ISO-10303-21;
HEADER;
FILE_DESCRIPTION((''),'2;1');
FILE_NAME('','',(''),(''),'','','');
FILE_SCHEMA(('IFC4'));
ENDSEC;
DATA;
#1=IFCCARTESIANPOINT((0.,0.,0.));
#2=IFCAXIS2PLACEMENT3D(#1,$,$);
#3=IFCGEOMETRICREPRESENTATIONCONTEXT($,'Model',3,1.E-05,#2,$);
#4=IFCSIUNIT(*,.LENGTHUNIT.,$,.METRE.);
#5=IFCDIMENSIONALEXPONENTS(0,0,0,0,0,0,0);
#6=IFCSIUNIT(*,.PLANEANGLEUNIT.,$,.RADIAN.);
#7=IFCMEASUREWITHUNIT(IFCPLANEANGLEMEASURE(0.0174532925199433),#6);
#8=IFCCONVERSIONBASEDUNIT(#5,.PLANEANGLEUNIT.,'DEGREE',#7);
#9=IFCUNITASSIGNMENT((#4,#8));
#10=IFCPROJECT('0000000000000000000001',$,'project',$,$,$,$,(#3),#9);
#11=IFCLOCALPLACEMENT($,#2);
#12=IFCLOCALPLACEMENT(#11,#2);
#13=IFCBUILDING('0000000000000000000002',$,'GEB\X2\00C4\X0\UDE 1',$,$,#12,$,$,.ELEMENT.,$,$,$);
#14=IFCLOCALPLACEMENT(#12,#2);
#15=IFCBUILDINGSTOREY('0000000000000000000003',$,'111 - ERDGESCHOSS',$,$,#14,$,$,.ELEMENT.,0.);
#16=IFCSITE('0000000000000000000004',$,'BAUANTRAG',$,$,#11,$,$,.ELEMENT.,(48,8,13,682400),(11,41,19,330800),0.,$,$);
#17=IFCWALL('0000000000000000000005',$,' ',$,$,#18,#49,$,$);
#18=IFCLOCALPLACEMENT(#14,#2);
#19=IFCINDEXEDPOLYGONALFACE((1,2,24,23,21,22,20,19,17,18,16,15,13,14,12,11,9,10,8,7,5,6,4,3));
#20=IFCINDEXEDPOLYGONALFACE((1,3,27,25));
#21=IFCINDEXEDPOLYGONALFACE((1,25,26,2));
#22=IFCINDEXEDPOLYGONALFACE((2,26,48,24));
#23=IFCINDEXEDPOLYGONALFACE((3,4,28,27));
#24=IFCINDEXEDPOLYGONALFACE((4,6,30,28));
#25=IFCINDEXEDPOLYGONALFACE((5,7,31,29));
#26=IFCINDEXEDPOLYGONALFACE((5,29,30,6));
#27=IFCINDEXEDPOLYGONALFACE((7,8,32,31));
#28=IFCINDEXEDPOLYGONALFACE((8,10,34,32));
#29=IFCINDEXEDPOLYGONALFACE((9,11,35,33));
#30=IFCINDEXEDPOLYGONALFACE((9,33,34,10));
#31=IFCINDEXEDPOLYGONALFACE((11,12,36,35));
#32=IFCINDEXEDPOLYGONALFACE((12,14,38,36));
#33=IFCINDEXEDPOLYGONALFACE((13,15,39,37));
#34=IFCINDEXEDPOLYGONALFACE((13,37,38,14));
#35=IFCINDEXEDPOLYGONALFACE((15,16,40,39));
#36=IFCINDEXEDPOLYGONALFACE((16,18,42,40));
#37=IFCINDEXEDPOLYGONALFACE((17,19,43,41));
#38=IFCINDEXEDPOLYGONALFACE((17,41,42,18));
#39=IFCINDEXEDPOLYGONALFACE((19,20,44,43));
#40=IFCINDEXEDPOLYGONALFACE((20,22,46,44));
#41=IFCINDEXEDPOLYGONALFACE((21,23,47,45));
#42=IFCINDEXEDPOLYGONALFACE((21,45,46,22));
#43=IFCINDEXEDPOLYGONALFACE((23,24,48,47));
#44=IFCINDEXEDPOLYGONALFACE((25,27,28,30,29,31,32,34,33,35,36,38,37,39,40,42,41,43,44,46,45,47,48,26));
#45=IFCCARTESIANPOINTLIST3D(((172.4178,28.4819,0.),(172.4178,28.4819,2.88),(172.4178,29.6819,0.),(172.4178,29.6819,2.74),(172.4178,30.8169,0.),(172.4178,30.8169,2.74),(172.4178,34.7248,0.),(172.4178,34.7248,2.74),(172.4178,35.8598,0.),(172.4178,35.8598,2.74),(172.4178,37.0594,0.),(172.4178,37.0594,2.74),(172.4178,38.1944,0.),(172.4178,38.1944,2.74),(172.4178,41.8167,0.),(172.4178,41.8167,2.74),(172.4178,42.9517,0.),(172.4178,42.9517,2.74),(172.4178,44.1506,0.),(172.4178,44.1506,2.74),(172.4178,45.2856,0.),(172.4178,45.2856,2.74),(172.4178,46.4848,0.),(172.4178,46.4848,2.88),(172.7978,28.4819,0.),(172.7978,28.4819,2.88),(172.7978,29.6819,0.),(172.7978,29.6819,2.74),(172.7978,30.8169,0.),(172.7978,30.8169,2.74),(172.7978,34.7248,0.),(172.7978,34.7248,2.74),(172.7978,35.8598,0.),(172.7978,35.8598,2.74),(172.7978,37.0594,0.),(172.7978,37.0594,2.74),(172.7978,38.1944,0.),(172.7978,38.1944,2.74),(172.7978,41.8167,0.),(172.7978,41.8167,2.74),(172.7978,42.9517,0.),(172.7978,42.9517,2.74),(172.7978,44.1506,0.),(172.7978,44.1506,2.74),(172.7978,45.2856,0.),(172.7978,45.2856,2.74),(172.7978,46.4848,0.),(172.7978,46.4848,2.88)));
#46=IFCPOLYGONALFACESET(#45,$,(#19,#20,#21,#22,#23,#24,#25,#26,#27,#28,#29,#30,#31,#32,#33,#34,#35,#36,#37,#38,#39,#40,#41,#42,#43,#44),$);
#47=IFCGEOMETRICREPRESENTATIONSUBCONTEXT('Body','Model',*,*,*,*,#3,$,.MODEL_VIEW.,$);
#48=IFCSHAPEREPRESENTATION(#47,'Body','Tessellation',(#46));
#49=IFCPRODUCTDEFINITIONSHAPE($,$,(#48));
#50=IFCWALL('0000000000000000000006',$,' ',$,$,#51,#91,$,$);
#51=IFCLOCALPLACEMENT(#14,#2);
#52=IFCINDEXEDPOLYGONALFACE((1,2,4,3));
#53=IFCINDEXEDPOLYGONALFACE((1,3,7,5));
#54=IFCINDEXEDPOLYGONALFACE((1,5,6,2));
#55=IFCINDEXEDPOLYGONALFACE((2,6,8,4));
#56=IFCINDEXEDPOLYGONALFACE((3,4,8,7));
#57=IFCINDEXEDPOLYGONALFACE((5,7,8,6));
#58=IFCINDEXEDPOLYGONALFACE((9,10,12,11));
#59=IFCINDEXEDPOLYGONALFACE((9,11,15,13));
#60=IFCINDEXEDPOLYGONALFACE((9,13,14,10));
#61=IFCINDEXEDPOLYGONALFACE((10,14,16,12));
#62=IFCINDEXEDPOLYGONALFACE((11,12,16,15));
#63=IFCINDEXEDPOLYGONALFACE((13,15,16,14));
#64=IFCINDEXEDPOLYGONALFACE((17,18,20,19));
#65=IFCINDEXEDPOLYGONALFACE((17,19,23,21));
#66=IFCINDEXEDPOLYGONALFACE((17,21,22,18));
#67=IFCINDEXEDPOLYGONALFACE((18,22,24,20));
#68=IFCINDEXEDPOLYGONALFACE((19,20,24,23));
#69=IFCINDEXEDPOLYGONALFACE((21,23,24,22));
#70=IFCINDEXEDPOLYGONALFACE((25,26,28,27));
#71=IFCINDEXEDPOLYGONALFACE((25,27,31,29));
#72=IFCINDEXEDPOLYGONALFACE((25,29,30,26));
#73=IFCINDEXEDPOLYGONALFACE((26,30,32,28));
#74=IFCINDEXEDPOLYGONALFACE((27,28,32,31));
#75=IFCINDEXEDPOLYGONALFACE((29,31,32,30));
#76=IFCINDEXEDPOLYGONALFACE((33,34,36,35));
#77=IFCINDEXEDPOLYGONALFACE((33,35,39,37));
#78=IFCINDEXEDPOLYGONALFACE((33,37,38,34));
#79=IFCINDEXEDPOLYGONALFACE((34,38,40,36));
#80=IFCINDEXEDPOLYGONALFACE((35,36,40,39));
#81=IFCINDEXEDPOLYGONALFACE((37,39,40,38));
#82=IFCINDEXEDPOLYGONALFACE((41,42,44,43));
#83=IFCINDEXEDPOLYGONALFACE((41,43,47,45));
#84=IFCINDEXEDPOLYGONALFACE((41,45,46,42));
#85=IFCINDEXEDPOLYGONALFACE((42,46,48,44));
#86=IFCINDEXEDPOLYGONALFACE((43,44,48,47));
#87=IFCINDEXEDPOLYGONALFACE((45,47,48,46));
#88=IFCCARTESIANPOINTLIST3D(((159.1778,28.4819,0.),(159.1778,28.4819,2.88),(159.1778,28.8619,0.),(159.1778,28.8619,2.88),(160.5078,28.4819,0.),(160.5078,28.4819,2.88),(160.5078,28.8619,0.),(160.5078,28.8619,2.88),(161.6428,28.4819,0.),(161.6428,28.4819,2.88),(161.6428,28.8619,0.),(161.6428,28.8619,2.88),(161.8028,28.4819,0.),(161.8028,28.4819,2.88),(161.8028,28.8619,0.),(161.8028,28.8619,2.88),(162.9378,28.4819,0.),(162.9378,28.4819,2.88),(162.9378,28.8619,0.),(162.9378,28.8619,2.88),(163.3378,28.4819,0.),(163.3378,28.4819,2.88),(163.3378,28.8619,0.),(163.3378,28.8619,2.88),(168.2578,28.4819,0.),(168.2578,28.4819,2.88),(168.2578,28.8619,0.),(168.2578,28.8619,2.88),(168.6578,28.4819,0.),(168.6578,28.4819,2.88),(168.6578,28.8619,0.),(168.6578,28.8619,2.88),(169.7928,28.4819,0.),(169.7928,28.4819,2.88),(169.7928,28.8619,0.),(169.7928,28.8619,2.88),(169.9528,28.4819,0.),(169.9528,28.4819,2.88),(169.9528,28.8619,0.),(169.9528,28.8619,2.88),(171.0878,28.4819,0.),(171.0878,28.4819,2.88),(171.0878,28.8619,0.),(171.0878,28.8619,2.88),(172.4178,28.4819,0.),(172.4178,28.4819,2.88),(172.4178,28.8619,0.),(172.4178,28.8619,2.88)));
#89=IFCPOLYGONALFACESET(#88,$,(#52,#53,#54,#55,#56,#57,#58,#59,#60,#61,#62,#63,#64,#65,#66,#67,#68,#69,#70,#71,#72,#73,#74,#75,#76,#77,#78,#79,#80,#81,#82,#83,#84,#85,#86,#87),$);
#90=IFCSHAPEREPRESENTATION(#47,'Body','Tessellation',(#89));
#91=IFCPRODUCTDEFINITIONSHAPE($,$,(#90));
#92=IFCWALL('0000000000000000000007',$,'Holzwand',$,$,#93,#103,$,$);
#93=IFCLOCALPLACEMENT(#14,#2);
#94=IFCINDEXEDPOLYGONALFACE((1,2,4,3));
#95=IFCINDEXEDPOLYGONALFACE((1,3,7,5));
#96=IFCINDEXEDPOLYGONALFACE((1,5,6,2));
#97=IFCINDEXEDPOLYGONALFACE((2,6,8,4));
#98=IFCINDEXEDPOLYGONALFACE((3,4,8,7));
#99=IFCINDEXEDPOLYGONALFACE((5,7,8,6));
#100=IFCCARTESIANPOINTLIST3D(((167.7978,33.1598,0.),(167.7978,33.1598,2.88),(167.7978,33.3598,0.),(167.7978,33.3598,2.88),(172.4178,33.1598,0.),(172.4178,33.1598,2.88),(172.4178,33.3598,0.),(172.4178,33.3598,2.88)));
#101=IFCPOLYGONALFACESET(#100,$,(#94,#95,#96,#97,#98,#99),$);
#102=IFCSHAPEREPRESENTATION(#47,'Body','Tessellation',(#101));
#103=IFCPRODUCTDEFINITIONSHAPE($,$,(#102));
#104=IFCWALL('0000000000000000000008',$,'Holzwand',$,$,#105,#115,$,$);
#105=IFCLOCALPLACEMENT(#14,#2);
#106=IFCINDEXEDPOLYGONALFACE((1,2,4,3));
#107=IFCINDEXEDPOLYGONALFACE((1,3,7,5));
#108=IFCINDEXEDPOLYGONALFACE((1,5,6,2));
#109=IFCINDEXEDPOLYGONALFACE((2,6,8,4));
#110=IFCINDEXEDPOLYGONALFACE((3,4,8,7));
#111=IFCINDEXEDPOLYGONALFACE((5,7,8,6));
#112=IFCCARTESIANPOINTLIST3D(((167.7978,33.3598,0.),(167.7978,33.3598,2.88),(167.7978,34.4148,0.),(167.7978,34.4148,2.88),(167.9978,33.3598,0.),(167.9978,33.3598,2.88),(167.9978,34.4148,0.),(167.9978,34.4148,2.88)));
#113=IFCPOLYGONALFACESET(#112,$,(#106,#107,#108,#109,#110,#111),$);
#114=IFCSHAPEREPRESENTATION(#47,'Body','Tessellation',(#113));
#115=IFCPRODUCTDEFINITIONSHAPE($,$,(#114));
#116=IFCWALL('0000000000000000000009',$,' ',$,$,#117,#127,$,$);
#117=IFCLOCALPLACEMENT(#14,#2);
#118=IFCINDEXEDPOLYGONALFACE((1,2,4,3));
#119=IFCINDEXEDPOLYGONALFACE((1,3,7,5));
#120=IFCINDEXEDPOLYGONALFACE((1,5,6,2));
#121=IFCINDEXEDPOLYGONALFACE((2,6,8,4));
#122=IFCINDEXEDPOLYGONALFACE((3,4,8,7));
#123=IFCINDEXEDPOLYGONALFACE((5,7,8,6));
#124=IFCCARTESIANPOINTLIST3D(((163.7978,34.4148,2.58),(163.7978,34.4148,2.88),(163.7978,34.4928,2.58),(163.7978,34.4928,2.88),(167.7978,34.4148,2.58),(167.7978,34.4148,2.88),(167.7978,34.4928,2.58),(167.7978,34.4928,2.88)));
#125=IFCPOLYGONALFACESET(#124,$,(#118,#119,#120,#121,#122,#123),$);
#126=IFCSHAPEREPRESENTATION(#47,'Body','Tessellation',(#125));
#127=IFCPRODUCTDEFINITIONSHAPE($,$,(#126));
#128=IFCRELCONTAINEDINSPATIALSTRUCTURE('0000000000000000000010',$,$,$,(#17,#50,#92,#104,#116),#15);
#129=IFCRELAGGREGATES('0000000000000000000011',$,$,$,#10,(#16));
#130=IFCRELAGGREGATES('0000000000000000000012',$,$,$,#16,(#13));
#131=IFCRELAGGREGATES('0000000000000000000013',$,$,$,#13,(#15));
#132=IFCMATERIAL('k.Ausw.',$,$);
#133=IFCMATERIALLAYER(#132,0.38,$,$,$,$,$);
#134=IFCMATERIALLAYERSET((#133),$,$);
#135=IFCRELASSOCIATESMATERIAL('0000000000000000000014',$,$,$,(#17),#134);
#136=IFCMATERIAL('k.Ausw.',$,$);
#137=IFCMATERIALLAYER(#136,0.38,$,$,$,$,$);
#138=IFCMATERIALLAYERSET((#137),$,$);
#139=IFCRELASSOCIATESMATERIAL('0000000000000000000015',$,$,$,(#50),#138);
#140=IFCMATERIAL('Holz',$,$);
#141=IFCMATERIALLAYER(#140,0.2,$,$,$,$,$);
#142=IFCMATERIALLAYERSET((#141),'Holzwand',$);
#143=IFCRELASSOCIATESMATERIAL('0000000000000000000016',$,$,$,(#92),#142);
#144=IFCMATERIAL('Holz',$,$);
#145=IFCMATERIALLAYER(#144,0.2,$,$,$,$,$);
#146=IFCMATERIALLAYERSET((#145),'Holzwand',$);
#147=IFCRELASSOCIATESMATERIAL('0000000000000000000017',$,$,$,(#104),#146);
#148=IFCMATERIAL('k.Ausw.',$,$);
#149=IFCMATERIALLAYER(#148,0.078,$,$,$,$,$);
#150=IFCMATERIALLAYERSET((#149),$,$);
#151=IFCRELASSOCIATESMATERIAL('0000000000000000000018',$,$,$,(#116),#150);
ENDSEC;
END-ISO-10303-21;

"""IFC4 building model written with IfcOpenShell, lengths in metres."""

from ifc_helpers import new_model, entity, si_unit, converted_unit, frame, frame_2d, origin, origin_with_axes, place, context, subcontext, project, spatial, polyline, rectangle, outline, extrude, material, layer, layer_set, layer_usage, element, save


model = new_model("IFC4")

# Units and contexts
model_context = context("Model", 3, precision=1e-05, world=origin())
body_context = subcontext(model_context, "Body", "Model", "MODEL_VIEW")
ifc_project = project(units=[si_unit("LENGTHUNIT", "METRE"), converted_unit("PLANEANGLEUNIT", "DEGREE", entity("IfcPlaneAngleMeasure", 0.0174532925199433), si_unit("PLANEANGLEUNIT", "RADIAN"), dimensions=[0, 0, 0, 0, 0, 0, 0])], contexts=[model_context])

# Site, building, storey
site_placement = place(None, origin())
site = spatial("IfcSite", under=ifc_project, at=site_placement, Name="BAUANTRAG", CompositionType="ELEMENT", RefLatitude=(48, 8, 13, 682400), RefLongitude=(11, 41, 19, 330800), RefElevation=0.0)
building_placement = place(site_placement, origin())
building = spatial("IfcBuilding", under=site, at=building_placement, Name="GEBÄUDE 1", CompositionType="ELEMENT")
storey_placement = place(building_placement, origin())
storey = spatial("IfcBuildingStorey", under=building, at=storey_placement, Name="111 - ERDGESCHOSS", CompositionType="ELEMENT", Elevation=0.0)

# Walls, openings
ifc_material_1 = material(Name="k.Ausw.")
ifc_layer_1 = layer(ifc_material_1, 0.38)
ifc_layer_set_1 = layer_set([ifc_layer_1])
ifc_layer_usage_1 = layer_usage(ifc_layer_set_1, "AXIS2", "POSITIVE", 0.0)
wall_1_placement = place(storey_placement, frame((172.7978, 28.4819, 0.0), z_axis=(0.0, 0.0, 1.0), x_axis=(0.0, 1.0, 0.0)))
wall_1 = element("IfcWall", 1, at=wall_1_placement, inside=storey, material=ifc_layer_usage_1, Name=" ", context=body_context, shape_type="SweptSolid", body=[
    extrude(rectangle(XDim=18.0029, YDim=0.38, at=frame_2d((9.0014, 0.19), x_axis=(1.0, 0.0))), origin_with_axes(), (0.0, 0.0, 1.0), 2.88),
])
opening_1_placement = place(wall_1_placement, frame((8.5775, 0.0, 0.0), z_axis=(0.0, 1.0, 0.0), x_axis=(0.0, 0.0, 1.0)))
element("IfcOpeningElement", 2, at=opening_1_placement, cuts=wall_1, ObjectType="Opening", context=body_context, shape_type="SweptSolid", body=[
    extrude(outline(polyline([(0.0, 1.135), (2.74, 1.135), (2.74, 0.0), (0.0, 0.0), (0.0, 1.135)])), origin_with_axes(), (0.0, 0.0, 1.0), 0.38),
])
opening_2_placement = place(wall_1_placement, frame((15.6687, 0.0, 0.0), z_axis=(0.0, 1.0, 0.0), x_axis=(0.0, 0.0, 1.0)))
element("IfcOpeningElement", 3, at=opening_2_placement, cuts=wall_1, ObjectType="Opening", context=body_context, shape_type="SweptSolid", body=[
    extrude(outline(polyline([(0.0, 1.135), (2.74, 1.135), (2.74, 0.0), (0.0, 0.0), (0.0, 1.135)])), origin_with_axes(), (0.0, 0.0, 1.0), 0.38),
])
opening_3_placement = place(wall_1_placement, frame((1.2, 0.0, 0.0), z_axis=(0.0, 1.0, 0.0), x_axis=(0.0, 0.0, 1.0)))
element("IfcOpeningElement", 4, at=opening_3_placement, cuts=wall_1, ObjectType="Opening", context=body_context, shape_type="SweptSolid", body=[
    extrude(outline(polyline([(0.0, 1.135), (2.74, 1.135), (2.74, 0.0), (0.0, 0.0), (0.0, 1.135)])), origin_with_axes(), (0.0, 0.0, 1.0), 0.38),
])
opening_4_placement = place(wall_1_placement, frame((13.3348, 0.0, 0.0), z_axis=(0.0, 1.0, 0.0), x_axis=(0.0, 0.0, 1.0)))
element("IfcOpeningElement", 5, at=opening_4_placement, cuts=wall_1, ObjectType="Opening", context=body_context, shape_type="SweptSolid", body=[
    extrude(outline(polyline([(0.0, 1.135), (2.74, 1.135), (2.74, 0.0), (0.0, 0.0), (0.0, 1.135)])), origin_with_axes(), (0.0, 0.0, 1.0), 0.38),
])
opening_5_placement = place(wall_1_placement, frame((6.2429, 0.0, 0.0), z_axis=(0.0, 1.0, 0.0), x_axis=(0.0, 0.0, 1.0)))
element("IfcOpeningElement", 6, at=opening_5_placement, cuts=wall_1, ObjectType="Opening", context=body_context, shape_type="SweptSolid", body=[
    extrude(outline(polyline([(0.0, 1.135), (2.74, 1.135), (2.74, 0.0), (0.0, 0.0), (0.0, 1.135)])), origin_with_axes(), (0.0, 0.0, 1.0), 0.38),
])
ifc_material_2 = material(Name="k.Ausw.")
ifc_layer_2 = layer(ifc_material_2, 0.38)
ifc_layer_set_2 = layer_set([ifc_layer_2])
ifc_layer_usage_2 = layer_usage(ifc_layer_set_2, "AXIS2", "POSITIVE", 0.0)
wall_2_placement = place(storey_placement, frame((159.1778, 28.4819, 0.0), z_axis=(0.0, 0.0, 1.0), x_axis=(1.0, 0.0, 0.0)))
wall_2 = element("IfcWall", 7, at=wall_2_placement, inside=storey, material=ifc_layer_usage_2, Name=" ", context=body_context, shape_type="SweptSolid", body=[
    extrude(rectangle(XDim=13.24, YDim=0.38, at=frame_2d((6.62, 0.19), x_axis=(1.0, 0.0))), origin_with_axes(), (0.0, 0.0, 1.0), 2.88),
])
opening_6_placement = place(wall_2_placement, frame((9.48, 0.0, 0.0), z_axis=(0.0, 1.0, 0.0), x_axis=(0.0, 0.0, 1.0)))
element("IfcOpeningElement", 8, at=opening_6_placement, cuts=wall_2, ObjectType="Opening", context=body_context, shape_type="SweptSolid", body=[
    extrude(outline(polyline([(0.0, 1.135), (2.88, 1.135), (2.88, 0.0), (0.0, 0.0), (0.0, 1.135)])), origin_with_axes(), (0.0, 0.0, 1.0), 0.38),
])
opening_7_placement = place(wall_2_placement, frame((4.16, 0.0, 0.0), z_axis=(0.0, 1.0, 0.0), x_axis=(0.0, 0.0, 1.0)))
element("IfcOpeningElement", 9, at=opening_7_placement, cuts=wall_2, ObjectType="Opening", context=body_context, shape_type="SweptSolid", body=[
    extrude(outline(polyline([(0.0, 4.92), (2.88, 4.92), (2.88, 0.0), (0.0, 0.0), (0.0, 4.92)])), origin_with_axes(), (0.0, 0.0, 1.0), 0.38),
])
opening_8_placement = place(wall_2_placement, frame((2.625, 0.0, 0.0), z_axis=(0.0, 1.0, 0.0), x_axis=(0.0, 0.0, 1.0)))
element("IfcOpeningElement", 10, at=opening_8_placement, cuts=wall_2, ObjectType="Opening", context=body_context, shape_type="SweptSolid", body=[
    extrude(outline(polyline([(0.0, 1.135), (2.88, 1.135), (2.88, 0.0), (0.0, 0.0), (0.0, 1.135)])), origin_with_axes(), (0.0, 0.0, 1.0), 0.38),
])
opening_9_placement = place(wall_2_placement, frame((1.33, 0.0, 0.0), z_axis=(0.0, 1.0, 0.0), x_axis=(0.0, 0.0, 1.0)))
element("IfcOpeningElement", 11, at=opening_9_placement, cuts=wall_2, ObjectType="Opening", context=body_context, shape_type="SweptSolid", body=[
    extrude(outline(polyline([(0.0, 1.135), (2.88, 1.135), (2.88, 0.0), (0.0, 0.0), (0.0, 1.135)])), origin_with_axes(), (0.0, 0.0, 1.0), 0.38),
])
opening_10_placement = place(wall_2_placement, frame((10.775, 0.0, 0.0), z_axis=(0.0, 1.0, 0.0), x_axis=(0.0, 0.0, 1.0)))
element("IfcOpeningElement", 12, at=opening_10_placement, cuts=wall_2, ObjectType="Opening", context=body_context, shape_type="SweptSolid", body=[
    extrude(outline(polyline([(0.0, 1.135), (2.88, 1.135), (2.88, 0.0), (0.0, 0.0), (0.0, 1.135)])), origin_with_axes(), (0.0, 0.0, 1.0), 0.38),
])

# Walls
ifc_material_3 = material(Name="Holz")
ifc_layer_3 = layer(ifc_material_3, 0.2)
ifc_layer_set_3 = layer_set([ifc_layer_3], Name="Holzwand")
ifc_layer_usage_3 = layer_usage(ifc_layer_set_3, "AXIS2", "POSITIVE", 0.0)
wall_3_placement = place(storey_placement, frame((167.7978, 33.1598, 0.0)))
element("IfcWall", 13, at=wall_3_placement, inside=storey, material=ifc_layer_usage_3, Name="Holzwand", context=body_context, shape_type="SweptSolid", body=[
    extrude(rectangle(XDim=4.62, YDim=0.2, at=frame_2d((2.31, 0.1), x_axis=(1.0, 0.0))), origin_with_axes(), (0.0, 0.0, 1.0), 2.88),
])
ifc_material_4 = material(Name="Holz")
ifc_layer_4 = layer(ifc_material_4, 0.2)
ifc_layer_set_4 = layer_set([ifc_layer_4], Name="Holzwand")
ifc_layer_usage_4 = layer_usage(ifc_layer_set_4, "AXIS2", "POSITIVE", 0.0)
wall_4_placement = place(storey_placement, frame((167.9978, 33.3598, 0.0), z_axis=(0.0, 0.0, 1.0), x_axis=(0.0, 1.0, 0.0)))
element("IfcWall", 14, at=wall_4_placement, inside=storey, material=ifc_layer_usage_4, Name="Holzwand", context=body_context, shape_type="SweptSolid", body=[
    extrude(rectangle(XDim=1.055, YDim=0.2, at=frame_2d((0.5275, 0.1), x_axis=(1.0, 0.0))), origin_with_axes(), (0.0, 0.0, 1.0), 2.88),
])

# Wall, opening
ifc_material_5 = material(Name="k.Ausw.")
ifc_layer_5 = layer(ifc_material_5, 0.078)
ifc_layer_set_5 = layer_set([ifc_layer_5])
ifc_layer_usage_5 = layer_usage(ifc_layer_set_5, "AXIS2", "POSITIVE", 0.0)
wall_5_placement = place(storey_placement, frame((163.7978, 34.4148, 0.0)))
wall_5 = element("IfcWall", 15, at=wall_5_placement, inside=storey, material=ifc_layer_usage_5, Name=" ", context=body_context, shape_type="SweptSolid", body=[
    extrude(rectangle(XDim=4.0, YDim=0.078, at=frame_2d((2.0, 0.039), x_axis=(1.0, 0.0))), origin_with_axes(), (0.0, 0.0, 1.0), 2.88),
])
opening_11_placement = place(wall_5_placement, frame((0.0, 0.0, -0.14), z_axis=(0.0, 1.0, 0.0), x_axis=(0.0, 0.0, 1.0)))
element("IfcOpeningElement", 16, at=opening_11_placement, cuts=wall_5, ObjectType="Opening", context=body_context, shape_type="SweptSolid", body=[
    extrude(outline(polyline([(0.0, 4.0), (2.72, 4.0), (2.72, 0.0), (0.0, 0.0), (0.0, 4.0)])), origin_with_axes(), (0.0, 0.0, 1.0), 0.078),
])

save(model, "model.ifc")
